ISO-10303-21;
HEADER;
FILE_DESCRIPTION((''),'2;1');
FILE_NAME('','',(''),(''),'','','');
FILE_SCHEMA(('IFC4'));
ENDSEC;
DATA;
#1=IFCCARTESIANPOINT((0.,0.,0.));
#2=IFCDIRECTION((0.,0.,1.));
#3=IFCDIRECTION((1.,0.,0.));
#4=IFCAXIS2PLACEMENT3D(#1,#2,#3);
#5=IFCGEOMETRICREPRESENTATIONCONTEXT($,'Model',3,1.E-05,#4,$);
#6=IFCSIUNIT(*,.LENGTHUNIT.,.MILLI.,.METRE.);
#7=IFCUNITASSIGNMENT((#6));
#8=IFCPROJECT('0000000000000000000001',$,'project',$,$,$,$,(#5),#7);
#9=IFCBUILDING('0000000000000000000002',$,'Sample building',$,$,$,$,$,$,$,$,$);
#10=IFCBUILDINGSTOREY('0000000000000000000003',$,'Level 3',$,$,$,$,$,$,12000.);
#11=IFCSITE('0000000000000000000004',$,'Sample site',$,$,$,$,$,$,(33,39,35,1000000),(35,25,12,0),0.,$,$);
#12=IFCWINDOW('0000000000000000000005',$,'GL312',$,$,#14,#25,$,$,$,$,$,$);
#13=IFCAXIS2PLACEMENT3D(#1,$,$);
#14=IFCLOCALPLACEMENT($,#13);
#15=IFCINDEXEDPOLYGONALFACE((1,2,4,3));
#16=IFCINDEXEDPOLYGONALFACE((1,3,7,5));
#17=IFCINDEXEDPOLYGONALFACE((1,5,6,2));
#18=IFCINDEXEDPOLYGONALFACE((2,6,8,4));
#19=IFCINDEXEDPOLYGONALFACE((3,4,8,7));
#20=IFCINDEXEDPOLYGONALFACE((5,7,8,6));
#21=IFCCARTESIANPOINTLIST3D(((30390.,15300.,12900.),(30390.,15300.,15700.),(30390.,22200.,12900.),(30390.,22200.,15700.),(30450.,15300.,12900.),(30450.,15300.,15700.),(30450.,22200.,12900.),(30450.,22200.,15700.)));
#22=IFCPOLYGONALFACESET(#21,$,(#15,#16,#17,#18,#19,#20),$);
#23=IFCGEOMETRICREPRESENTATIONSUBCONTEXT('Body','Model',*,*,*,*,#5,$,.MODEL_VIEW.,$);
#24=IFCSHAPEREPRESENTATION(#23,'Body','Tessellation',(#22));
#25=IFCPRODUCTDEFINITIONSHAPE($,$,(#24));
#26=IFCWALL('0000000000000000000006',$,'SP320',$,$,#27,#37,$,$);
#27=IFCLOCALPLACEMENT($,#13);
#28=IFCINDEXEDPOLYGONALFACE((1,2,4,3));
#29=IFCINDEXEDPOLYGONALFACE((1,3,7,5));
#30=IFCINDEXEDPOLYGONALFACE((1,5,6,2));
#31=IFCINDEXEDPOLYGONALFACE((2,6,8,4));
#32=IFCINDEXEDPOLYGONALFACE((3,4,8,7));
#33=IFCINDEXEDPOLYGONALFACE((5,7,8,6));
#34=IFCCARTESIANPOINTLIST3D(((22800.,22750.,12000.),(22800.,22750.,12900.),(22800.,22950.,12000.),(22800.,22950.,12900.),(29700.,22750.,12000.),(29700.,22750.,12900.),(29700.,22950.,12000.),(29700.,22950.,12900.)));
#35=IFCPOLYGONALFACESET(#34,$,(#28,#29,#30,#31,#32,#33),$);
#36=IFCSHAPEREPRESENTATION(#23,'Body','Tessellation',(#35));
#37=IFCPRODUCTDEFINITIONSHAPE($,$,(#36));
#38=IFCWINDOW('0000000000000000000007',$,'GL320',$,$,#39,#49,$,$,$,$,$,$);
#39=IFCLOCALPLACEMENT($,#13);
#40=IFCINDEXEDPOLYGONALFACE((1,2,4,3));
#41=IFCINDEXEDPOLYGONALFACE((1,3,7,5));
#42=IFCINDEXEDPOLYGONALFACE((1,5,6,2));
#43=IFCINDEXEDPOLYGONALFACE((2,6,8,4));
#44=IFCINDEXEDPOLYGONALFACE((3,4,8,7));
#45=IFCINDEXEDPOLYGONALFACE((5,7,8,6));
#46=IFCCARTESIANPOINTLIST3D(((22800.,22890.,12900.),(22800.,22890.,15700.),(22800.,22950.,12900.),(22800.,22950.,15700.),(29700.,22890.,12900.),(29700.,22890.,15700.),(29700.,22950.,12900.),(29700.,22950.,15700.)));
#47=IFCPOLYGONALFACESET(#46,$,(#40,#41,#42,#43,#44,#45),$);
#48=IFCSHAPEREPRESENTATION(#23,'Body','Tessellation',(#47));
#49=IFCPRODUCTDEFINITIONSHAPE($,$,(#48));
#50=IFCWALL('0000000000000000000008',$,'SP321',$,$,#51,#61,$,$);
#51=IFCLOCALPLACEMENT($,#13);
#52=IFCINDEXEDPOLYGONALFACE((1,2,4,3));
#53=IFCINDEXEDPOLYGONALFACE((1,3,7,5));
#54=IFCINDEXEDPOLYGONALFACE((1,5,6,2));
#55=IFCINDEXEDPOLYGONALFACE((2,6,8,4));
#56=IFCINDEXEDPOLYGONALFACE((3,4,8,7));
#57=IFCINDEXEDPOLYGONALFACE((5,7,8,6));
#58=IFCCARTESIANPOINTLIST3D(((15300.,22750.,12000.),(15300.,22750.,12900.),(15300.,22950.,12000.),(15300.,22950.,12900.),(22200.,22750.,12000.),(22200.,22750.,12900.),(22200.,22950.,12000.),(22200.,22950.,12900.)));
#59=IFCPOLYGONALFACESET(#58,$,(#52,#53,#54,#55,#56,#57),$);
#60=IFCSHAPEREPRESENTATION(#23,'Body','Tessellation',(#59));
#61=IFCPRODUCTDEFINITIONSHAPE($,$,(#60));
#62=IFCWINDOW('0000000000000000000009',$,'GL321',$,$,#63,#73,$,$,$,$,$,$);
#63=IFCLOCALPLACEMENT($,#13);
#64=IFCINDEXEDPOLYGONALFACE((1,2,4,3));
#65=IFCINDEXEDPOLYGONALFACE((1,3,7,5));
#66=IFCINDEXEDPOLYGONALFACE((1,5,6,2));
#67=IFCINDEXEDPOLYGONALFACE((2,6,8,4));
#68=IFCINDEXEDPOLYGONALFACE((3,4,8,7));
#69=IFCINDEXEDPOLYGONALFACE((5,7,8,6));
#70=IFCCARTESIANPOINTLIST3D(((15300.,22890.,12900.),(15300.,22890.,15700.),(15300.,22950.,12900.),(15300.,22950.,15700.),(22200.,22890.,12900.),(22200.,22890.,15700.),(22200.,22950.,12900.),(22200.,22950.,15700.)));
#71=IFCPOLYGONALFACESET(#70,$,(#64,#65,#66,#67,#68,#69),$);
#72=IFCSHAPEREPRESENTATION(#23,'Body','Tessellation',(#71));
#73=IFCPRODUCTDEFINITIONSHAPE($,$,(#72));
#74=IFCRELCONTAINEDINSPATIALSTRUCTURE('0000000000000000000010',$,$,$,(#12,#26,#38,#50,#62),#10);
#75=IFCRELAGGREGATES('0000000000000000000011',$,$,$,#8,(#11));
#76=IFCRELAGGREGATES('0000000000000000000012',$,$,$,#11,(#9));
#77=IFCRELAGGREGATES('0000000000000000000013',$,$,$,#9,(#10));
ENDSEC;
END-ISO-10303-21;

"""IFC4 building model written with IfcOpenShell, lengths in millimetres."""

from ifc_helpers import new_model, si_unit, frame, origin_with_axes, place, context, subcontext, project, spatial, indexed_curve, outline, extrude, element, save


model = new_model("IFC4")

# Units and contexts
model_context = context("Model", 3, precision=1e-05, world=origin_with_axes())
body_context = subcontext(model_context, "Body", "Model", "MODEL_VIEW")
ifc_project = project(units=[si_unit("LENGTHUNIT", "METRE", prefix="MILLI")], contexts=[model_context])

# Site, building, storey
site = spatial("IfcSite", under=ifc_project, Name="Sample site", RefLatitude=(33, 39, 35, 1000000), RefLongitude=(35, 25, 12, 0), RefElevation=0.0)
building = spatial("IfcBuilding", under=site, Name="Sample building")
storey = spatial("IfcBuildingStorey", under=building, Name="Level 3", Elevation=12000.0)

# Window
window_1_placement = place(None, frame((30450.0, 15300.0, 12900.0), z_axis=(0.0, 0.0, 1.0), x_axis=(0.0, 1.0, 0.0)))
element("IfcWindow", 1, at=window_1_placement, inside=storey, Name="GL312", context=body_context, shape_type="SweptSolid", body=[
    extrude(outline(indexed_curve([(0.0, 0.0), (0.0, 60.0), (6900.0, 60.0), (6900.0, 0.0), (0.0, 0.0)], self_intersect=False)), origin_with_axes(), (0.0, 0.0, 1.0), 2800.0),
])

# Wall
wall_1_placement = place(None, frame((29700.0, 22950.0, 12000.0), z_axis=(0.0, 0.0, 1.0), x_axis=(-1.0, 0.0, 0.0)))
element("IfcWall", 2, at=wall_1_placement, inside=storey, Name="SP320", context=body_context, shape_type="SweptSolid", body=[
    extrude(outline(indexed_curve([(0.0, 0.0), (0.0, 200.0), (6900.0, 200.0), (6900.0, 0.0), (0.0, 0.0)], self_intersect=False)), origin_with_axes(), (0.0, 0.0, 1.0), 900.0),
])

# Window
window_2_placement = place(None, frame((29700.0, 22950.0, 12900.0), z_axis=(0.0, 0.0, 1.0), x_axis=(-1.0, 0.0, 0.0)))
element("IfcWindow", 3, at=window_2_placement, inside=storey, Name="GL320", context=body_context, shape_type="SweptSolid", body=[
    extrude(outline(indexed_curve([(0.0, 0.0), (0.0, 60.0), (6900.0, 60.0), (6900.0, 0.0), (0.0, 0.0)], self_intersect=False)), origin_with_axes(), (0.0, 0.0, 1.0), 2800.0),
])

# Wall
wall_2_placement = place(None, frame((22200.0, 22950.0, 12000.0), z_axis=(0.0, 0.0, 1.0), x_axis=(-1.0, 0.0, 0.0)))
element("IfcWall", 4, at=wall_2_placement, inside=storey, Name="SP321", context=body_context, shape_type="SweptSolid", body=[
    extrude(outline(indexed_curve([(0.0, 0.0), (0.0, 200.0), (6900.0, 200.0), (6900.0, 0.0), (0.0, 0.0)], self_intersect=False)), origin_with_axes(), (0.0, 0.0, 1.0), 900.0),
])

# Window
window_3_placement = place(None, frame((22200.0, 22950.0, 12900.0), z_axis=(0.0, 0.0, 1.0), x_axis=(-1.0, 0.0, 0.0)))
element("IfcWindow", 5, at=window_3_placement, inside=storey, Name="GL321", context=body_context, shape_type="SweptSolid", body=[
    extrude(outline(indexed_curve([(0.0, 0.0), (0.0, 60.0), (6900.0, 60.0), (6900.0, 0.0), (0.0, 0.0)], self_intersect=False)), origin_with_axes(), (0.0, 0.0, 1.0), 2800.0),
])

save(model, "model.ifc")
